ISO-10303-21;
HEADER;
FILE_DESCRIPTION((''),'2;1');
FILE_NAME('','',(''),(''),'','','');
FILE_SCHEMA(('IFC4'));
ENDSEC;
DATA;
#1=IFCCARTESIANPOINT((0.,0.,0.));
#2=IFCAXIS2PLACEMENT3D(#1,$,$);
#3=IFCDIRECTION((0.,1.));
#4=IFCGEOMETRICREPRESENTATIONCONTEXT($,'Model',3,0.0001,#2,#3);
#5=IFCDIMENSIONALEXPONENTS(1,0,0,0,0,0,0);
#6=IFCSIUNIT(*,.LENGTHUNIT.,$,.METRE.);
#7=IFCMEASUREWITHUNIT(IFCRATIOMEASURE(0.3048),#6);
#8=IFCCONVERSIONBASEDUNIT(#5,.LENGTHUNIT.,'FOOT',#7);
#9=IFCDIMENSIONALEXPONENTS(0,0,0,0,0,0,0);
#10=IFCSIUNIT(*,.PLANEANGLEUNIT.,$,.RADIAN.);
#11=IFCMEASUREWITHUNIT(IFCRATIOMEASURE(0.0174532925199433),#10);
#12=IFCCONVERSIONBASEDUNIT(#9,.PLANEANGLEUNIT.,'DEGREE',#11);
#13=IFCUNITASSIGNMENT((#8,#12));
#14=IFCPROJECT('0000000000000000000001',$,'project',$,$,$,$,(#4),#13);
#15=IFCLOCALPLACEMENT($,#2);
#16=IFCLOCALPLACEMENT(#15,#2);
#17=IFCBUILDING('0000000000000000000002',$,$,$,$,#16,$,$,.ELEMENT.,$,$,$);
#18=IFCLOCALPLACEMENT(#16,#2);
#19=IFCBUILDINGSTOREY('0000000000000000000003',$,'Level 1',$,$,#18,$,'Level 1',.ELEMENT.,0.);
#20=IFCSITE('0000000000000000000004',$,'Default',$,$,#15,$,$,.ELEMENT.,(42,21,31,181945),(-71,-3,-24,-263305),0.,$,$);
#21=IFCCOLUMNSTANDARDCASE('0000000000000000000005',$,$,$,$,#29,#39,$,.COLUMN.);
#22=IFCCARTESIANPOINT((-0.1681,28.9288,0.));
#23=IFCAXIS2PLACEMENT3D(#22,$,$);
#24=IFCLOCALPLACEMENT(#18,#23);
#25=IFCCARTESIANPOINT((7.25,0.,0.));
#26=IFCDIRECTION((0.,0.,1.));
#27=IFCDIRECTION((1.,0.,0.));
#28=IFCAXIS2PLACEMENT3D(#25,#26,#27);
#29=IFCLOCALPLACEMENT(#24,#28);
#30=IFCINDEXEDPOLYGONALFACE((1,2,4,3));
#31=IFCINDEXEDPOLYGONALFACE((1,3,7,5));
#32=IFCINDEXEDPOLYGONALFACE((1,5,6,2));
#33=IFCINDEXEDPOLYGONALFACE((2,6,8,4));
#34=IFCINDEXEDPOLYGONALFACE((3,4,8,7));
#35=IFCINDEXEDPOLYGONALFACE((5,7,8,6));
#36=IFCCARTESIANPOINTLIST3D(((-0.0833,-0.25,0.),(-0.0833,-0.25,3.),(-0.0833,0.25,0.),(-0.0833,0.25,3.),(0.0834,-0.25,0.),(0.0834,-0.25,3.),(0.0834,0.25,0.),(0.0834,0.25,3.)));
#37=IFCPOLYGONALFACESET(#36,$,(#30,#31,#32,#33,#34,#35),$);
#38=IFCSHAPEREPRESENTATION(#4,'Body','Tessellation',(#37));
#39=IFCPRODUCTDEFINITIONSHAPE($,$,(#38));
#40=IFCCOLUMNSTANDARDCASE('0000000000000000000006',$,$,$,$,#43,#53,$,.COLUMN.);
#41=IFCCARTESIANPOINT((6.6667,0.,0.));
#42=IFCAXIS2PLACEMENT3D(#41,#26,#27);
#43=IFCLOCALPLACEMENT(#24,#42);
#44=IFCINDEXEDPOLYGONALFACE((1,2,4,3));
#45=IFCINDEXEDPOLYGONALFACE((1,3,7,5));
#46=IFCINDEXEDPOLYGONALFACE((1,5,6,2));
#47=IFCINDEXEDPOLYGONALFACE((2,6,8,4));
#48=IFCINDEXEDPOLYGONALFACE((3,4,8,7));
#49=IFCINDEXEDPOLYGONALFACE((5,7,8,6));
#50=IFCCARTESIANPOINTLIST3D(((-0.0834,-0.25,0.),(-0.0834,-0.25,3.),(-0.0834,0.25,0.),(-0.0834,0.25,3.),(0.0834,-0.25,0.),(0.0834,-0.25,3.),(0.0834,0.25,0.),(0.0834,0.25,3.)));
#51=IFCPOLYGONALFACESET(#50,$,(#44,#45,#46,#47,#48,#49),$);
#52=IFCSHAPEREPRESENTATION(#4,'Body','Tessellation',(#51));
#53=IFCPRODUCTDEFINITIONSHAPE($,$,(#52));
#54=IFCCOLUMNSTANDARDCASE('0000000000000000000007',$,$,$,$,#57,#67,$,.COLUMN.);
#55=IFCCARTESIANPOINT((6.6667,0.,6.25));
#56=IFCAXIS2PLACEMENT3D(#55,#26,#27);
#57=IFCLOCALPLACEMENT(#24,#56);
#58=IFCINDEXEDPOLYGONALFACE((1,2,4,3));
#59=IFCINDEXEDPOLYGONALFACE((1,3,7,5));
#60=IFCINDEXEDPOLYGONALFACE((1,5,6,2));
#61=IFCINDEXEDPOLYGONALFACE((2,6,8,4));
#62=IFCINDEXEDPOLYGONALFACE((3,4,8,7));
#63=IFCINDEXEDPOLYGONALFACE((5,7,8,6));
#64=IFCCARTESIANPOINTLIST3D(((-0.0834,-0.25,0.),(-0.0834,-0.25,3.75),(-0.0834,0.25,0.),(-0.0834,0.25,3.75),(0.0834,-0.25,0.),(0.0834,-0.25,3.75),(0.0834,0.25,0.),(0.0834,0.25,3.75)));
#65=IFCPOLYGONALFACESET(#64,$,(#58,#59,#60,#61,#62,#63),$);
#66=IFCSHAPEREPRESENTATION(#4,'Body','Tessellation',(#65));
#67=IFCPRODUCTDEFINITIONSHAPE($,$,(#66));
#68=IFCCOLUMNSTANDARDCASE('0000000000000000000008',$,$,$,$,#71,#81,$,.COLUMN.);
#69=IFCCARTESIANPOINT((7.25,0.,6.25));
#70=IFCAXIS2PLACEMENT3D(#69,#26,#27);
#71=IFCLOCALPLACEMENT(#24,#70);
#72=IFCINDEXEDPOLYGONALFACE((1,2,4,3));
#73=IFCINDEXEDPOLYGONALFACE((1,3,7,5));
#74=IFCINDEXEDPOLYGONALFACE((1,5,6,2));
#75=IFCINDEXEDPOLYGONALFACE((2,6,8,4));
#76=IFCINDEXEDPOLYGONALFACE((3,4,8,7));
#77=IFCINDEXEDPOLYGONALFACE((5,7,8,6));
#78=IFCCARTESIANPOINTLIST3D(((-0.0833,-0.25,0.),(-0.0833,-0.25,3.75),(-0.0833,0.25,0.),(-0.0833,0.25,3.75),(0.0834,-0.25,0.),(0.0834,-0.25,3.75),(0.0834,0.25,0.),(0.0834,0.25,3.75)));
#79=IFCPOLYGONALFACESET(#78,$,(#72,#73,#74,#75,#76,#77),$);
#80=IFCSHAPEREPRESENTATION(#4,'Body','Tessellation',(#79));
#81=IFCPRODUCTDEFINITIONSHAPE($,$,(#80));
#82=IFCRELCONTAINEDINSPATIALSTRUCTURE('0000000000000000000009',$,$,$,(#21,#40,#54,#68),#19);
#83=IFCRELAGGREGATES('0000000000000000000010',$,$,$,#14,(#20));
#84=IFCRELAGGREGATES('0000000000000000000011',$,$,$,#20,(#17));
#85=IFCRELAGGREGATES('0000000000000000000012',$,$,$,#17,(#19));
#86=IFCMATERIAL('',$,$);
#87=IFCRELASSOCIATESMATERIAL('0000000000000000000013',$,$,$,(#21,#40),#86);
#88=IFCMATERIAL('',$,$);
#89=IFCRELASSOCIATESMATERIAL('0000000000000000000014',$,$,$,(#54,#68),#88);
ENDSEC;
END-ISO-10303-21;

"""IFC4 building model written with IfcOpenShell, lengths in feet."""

from ifc_helpers import new_model, entity, si_unit, converted_unit, direction, frame, origin, place, context, project, spatial, rectangle, extrude, material, element, save


model = new_model("IFC4")

# Units and contexts
model_context = context("Model", 3, precision=0.0001, world=origin(), true_north=direction((0.0, 1.0)))
ifc_project = project(units=[converted_unit("LENGTHUNIT", "FOOT", entity("IfcRatioMeasure", 0.3048), si_unit("LENGTHUNIT", "METRE"), dimensions=[1, 0, 0, 0, 0, 0, 0]), converted_unit("PLANEANGLEUNIT", "DEGREE", entity("IfcRatioMeasure", 0.0174532925199433), si_unit("PLANEANGLEUNIT", "RADIAN"), dimensions=[0, 0, 0, 0, 0, 0, 0])], contexts=[model_context])

# Site, building, storey
site_placement = place(None, origin())
site = spatial("IfcSite", under=ifc_project, at=site_placement, Name="Default", CompositionType="ELEMENT", RefLatitude=(42, 21, 31, 181945), RefLongitude=(-71, -3, -24, -263305), RefElevation=0.0)
building_placement = place(site_placement, origin())
building = spatial("IfcBuilding", under=site, at=building_placement, CompositionType="ELEMENT")
storey_placement = place(building_placement, origin())
storey = spatial("IfcBuildingStorey", under=building, at=storey_placement, Name="Level 1", LongName="Level 1", CompositionType="ELEMENT", Elevation=0.0)

# Columns
placement = place(storey_placement, frame((-0.1681, 28.9288, 0.0)))
ifc_material_1 = material(Name="")
for number, where, z_axis, x_axis in (
    (1, (7.25, 0.0, 0.0), (0.0, 0.0, 1.0), (1.0, 0.0, 0.0)),
    (2, (6.6667, 0.0, 0.0), (0.0, 0.0, 1.0), (1.0, 0.0, 0.0)),
):
    element("IfcColumnStandardCase", number, at=place(placement, frame(where, z_axis=z_axis, x_axis=x_axis)), inside=storey, material=ifc_material_1, PredefinedType="COLUMN", context=model_context, shape_type="SweptSolid", body=[
        extrude(rectangle(XDim=0.1667, YDim=0.5), origin(), (0.0, 0.0, 1.0), 3.0),
    ])
ifc_material_2 = material(Name="")
for number, where, z_axis, x_axis in (
    (3, (6.6667, 0.0, 6.25), (0.0, 0.0, 1.0), (1.0, 0.0, 0.0)),
    (4, (7.25, 0.0, 6.25), (0.0, 0.0, 1.0), (1.0, 0.0, 0.0)),
):
    element("IfcColumnStandardCase", number, at=place(placement, frame(where, z_axis=z_axis, x_axis=x_axis)), inside=storey, material=ifc_material_2, PredefinedType="COLUMN", context=model_context, shape_type="SweptSolid", body=[
        extrude(rectangle(XDim=0.1667, YDim=0.5), origin(), (0.0, 0.0, 1.0), 3.75),
    ])

save(model, "model.ifc")
